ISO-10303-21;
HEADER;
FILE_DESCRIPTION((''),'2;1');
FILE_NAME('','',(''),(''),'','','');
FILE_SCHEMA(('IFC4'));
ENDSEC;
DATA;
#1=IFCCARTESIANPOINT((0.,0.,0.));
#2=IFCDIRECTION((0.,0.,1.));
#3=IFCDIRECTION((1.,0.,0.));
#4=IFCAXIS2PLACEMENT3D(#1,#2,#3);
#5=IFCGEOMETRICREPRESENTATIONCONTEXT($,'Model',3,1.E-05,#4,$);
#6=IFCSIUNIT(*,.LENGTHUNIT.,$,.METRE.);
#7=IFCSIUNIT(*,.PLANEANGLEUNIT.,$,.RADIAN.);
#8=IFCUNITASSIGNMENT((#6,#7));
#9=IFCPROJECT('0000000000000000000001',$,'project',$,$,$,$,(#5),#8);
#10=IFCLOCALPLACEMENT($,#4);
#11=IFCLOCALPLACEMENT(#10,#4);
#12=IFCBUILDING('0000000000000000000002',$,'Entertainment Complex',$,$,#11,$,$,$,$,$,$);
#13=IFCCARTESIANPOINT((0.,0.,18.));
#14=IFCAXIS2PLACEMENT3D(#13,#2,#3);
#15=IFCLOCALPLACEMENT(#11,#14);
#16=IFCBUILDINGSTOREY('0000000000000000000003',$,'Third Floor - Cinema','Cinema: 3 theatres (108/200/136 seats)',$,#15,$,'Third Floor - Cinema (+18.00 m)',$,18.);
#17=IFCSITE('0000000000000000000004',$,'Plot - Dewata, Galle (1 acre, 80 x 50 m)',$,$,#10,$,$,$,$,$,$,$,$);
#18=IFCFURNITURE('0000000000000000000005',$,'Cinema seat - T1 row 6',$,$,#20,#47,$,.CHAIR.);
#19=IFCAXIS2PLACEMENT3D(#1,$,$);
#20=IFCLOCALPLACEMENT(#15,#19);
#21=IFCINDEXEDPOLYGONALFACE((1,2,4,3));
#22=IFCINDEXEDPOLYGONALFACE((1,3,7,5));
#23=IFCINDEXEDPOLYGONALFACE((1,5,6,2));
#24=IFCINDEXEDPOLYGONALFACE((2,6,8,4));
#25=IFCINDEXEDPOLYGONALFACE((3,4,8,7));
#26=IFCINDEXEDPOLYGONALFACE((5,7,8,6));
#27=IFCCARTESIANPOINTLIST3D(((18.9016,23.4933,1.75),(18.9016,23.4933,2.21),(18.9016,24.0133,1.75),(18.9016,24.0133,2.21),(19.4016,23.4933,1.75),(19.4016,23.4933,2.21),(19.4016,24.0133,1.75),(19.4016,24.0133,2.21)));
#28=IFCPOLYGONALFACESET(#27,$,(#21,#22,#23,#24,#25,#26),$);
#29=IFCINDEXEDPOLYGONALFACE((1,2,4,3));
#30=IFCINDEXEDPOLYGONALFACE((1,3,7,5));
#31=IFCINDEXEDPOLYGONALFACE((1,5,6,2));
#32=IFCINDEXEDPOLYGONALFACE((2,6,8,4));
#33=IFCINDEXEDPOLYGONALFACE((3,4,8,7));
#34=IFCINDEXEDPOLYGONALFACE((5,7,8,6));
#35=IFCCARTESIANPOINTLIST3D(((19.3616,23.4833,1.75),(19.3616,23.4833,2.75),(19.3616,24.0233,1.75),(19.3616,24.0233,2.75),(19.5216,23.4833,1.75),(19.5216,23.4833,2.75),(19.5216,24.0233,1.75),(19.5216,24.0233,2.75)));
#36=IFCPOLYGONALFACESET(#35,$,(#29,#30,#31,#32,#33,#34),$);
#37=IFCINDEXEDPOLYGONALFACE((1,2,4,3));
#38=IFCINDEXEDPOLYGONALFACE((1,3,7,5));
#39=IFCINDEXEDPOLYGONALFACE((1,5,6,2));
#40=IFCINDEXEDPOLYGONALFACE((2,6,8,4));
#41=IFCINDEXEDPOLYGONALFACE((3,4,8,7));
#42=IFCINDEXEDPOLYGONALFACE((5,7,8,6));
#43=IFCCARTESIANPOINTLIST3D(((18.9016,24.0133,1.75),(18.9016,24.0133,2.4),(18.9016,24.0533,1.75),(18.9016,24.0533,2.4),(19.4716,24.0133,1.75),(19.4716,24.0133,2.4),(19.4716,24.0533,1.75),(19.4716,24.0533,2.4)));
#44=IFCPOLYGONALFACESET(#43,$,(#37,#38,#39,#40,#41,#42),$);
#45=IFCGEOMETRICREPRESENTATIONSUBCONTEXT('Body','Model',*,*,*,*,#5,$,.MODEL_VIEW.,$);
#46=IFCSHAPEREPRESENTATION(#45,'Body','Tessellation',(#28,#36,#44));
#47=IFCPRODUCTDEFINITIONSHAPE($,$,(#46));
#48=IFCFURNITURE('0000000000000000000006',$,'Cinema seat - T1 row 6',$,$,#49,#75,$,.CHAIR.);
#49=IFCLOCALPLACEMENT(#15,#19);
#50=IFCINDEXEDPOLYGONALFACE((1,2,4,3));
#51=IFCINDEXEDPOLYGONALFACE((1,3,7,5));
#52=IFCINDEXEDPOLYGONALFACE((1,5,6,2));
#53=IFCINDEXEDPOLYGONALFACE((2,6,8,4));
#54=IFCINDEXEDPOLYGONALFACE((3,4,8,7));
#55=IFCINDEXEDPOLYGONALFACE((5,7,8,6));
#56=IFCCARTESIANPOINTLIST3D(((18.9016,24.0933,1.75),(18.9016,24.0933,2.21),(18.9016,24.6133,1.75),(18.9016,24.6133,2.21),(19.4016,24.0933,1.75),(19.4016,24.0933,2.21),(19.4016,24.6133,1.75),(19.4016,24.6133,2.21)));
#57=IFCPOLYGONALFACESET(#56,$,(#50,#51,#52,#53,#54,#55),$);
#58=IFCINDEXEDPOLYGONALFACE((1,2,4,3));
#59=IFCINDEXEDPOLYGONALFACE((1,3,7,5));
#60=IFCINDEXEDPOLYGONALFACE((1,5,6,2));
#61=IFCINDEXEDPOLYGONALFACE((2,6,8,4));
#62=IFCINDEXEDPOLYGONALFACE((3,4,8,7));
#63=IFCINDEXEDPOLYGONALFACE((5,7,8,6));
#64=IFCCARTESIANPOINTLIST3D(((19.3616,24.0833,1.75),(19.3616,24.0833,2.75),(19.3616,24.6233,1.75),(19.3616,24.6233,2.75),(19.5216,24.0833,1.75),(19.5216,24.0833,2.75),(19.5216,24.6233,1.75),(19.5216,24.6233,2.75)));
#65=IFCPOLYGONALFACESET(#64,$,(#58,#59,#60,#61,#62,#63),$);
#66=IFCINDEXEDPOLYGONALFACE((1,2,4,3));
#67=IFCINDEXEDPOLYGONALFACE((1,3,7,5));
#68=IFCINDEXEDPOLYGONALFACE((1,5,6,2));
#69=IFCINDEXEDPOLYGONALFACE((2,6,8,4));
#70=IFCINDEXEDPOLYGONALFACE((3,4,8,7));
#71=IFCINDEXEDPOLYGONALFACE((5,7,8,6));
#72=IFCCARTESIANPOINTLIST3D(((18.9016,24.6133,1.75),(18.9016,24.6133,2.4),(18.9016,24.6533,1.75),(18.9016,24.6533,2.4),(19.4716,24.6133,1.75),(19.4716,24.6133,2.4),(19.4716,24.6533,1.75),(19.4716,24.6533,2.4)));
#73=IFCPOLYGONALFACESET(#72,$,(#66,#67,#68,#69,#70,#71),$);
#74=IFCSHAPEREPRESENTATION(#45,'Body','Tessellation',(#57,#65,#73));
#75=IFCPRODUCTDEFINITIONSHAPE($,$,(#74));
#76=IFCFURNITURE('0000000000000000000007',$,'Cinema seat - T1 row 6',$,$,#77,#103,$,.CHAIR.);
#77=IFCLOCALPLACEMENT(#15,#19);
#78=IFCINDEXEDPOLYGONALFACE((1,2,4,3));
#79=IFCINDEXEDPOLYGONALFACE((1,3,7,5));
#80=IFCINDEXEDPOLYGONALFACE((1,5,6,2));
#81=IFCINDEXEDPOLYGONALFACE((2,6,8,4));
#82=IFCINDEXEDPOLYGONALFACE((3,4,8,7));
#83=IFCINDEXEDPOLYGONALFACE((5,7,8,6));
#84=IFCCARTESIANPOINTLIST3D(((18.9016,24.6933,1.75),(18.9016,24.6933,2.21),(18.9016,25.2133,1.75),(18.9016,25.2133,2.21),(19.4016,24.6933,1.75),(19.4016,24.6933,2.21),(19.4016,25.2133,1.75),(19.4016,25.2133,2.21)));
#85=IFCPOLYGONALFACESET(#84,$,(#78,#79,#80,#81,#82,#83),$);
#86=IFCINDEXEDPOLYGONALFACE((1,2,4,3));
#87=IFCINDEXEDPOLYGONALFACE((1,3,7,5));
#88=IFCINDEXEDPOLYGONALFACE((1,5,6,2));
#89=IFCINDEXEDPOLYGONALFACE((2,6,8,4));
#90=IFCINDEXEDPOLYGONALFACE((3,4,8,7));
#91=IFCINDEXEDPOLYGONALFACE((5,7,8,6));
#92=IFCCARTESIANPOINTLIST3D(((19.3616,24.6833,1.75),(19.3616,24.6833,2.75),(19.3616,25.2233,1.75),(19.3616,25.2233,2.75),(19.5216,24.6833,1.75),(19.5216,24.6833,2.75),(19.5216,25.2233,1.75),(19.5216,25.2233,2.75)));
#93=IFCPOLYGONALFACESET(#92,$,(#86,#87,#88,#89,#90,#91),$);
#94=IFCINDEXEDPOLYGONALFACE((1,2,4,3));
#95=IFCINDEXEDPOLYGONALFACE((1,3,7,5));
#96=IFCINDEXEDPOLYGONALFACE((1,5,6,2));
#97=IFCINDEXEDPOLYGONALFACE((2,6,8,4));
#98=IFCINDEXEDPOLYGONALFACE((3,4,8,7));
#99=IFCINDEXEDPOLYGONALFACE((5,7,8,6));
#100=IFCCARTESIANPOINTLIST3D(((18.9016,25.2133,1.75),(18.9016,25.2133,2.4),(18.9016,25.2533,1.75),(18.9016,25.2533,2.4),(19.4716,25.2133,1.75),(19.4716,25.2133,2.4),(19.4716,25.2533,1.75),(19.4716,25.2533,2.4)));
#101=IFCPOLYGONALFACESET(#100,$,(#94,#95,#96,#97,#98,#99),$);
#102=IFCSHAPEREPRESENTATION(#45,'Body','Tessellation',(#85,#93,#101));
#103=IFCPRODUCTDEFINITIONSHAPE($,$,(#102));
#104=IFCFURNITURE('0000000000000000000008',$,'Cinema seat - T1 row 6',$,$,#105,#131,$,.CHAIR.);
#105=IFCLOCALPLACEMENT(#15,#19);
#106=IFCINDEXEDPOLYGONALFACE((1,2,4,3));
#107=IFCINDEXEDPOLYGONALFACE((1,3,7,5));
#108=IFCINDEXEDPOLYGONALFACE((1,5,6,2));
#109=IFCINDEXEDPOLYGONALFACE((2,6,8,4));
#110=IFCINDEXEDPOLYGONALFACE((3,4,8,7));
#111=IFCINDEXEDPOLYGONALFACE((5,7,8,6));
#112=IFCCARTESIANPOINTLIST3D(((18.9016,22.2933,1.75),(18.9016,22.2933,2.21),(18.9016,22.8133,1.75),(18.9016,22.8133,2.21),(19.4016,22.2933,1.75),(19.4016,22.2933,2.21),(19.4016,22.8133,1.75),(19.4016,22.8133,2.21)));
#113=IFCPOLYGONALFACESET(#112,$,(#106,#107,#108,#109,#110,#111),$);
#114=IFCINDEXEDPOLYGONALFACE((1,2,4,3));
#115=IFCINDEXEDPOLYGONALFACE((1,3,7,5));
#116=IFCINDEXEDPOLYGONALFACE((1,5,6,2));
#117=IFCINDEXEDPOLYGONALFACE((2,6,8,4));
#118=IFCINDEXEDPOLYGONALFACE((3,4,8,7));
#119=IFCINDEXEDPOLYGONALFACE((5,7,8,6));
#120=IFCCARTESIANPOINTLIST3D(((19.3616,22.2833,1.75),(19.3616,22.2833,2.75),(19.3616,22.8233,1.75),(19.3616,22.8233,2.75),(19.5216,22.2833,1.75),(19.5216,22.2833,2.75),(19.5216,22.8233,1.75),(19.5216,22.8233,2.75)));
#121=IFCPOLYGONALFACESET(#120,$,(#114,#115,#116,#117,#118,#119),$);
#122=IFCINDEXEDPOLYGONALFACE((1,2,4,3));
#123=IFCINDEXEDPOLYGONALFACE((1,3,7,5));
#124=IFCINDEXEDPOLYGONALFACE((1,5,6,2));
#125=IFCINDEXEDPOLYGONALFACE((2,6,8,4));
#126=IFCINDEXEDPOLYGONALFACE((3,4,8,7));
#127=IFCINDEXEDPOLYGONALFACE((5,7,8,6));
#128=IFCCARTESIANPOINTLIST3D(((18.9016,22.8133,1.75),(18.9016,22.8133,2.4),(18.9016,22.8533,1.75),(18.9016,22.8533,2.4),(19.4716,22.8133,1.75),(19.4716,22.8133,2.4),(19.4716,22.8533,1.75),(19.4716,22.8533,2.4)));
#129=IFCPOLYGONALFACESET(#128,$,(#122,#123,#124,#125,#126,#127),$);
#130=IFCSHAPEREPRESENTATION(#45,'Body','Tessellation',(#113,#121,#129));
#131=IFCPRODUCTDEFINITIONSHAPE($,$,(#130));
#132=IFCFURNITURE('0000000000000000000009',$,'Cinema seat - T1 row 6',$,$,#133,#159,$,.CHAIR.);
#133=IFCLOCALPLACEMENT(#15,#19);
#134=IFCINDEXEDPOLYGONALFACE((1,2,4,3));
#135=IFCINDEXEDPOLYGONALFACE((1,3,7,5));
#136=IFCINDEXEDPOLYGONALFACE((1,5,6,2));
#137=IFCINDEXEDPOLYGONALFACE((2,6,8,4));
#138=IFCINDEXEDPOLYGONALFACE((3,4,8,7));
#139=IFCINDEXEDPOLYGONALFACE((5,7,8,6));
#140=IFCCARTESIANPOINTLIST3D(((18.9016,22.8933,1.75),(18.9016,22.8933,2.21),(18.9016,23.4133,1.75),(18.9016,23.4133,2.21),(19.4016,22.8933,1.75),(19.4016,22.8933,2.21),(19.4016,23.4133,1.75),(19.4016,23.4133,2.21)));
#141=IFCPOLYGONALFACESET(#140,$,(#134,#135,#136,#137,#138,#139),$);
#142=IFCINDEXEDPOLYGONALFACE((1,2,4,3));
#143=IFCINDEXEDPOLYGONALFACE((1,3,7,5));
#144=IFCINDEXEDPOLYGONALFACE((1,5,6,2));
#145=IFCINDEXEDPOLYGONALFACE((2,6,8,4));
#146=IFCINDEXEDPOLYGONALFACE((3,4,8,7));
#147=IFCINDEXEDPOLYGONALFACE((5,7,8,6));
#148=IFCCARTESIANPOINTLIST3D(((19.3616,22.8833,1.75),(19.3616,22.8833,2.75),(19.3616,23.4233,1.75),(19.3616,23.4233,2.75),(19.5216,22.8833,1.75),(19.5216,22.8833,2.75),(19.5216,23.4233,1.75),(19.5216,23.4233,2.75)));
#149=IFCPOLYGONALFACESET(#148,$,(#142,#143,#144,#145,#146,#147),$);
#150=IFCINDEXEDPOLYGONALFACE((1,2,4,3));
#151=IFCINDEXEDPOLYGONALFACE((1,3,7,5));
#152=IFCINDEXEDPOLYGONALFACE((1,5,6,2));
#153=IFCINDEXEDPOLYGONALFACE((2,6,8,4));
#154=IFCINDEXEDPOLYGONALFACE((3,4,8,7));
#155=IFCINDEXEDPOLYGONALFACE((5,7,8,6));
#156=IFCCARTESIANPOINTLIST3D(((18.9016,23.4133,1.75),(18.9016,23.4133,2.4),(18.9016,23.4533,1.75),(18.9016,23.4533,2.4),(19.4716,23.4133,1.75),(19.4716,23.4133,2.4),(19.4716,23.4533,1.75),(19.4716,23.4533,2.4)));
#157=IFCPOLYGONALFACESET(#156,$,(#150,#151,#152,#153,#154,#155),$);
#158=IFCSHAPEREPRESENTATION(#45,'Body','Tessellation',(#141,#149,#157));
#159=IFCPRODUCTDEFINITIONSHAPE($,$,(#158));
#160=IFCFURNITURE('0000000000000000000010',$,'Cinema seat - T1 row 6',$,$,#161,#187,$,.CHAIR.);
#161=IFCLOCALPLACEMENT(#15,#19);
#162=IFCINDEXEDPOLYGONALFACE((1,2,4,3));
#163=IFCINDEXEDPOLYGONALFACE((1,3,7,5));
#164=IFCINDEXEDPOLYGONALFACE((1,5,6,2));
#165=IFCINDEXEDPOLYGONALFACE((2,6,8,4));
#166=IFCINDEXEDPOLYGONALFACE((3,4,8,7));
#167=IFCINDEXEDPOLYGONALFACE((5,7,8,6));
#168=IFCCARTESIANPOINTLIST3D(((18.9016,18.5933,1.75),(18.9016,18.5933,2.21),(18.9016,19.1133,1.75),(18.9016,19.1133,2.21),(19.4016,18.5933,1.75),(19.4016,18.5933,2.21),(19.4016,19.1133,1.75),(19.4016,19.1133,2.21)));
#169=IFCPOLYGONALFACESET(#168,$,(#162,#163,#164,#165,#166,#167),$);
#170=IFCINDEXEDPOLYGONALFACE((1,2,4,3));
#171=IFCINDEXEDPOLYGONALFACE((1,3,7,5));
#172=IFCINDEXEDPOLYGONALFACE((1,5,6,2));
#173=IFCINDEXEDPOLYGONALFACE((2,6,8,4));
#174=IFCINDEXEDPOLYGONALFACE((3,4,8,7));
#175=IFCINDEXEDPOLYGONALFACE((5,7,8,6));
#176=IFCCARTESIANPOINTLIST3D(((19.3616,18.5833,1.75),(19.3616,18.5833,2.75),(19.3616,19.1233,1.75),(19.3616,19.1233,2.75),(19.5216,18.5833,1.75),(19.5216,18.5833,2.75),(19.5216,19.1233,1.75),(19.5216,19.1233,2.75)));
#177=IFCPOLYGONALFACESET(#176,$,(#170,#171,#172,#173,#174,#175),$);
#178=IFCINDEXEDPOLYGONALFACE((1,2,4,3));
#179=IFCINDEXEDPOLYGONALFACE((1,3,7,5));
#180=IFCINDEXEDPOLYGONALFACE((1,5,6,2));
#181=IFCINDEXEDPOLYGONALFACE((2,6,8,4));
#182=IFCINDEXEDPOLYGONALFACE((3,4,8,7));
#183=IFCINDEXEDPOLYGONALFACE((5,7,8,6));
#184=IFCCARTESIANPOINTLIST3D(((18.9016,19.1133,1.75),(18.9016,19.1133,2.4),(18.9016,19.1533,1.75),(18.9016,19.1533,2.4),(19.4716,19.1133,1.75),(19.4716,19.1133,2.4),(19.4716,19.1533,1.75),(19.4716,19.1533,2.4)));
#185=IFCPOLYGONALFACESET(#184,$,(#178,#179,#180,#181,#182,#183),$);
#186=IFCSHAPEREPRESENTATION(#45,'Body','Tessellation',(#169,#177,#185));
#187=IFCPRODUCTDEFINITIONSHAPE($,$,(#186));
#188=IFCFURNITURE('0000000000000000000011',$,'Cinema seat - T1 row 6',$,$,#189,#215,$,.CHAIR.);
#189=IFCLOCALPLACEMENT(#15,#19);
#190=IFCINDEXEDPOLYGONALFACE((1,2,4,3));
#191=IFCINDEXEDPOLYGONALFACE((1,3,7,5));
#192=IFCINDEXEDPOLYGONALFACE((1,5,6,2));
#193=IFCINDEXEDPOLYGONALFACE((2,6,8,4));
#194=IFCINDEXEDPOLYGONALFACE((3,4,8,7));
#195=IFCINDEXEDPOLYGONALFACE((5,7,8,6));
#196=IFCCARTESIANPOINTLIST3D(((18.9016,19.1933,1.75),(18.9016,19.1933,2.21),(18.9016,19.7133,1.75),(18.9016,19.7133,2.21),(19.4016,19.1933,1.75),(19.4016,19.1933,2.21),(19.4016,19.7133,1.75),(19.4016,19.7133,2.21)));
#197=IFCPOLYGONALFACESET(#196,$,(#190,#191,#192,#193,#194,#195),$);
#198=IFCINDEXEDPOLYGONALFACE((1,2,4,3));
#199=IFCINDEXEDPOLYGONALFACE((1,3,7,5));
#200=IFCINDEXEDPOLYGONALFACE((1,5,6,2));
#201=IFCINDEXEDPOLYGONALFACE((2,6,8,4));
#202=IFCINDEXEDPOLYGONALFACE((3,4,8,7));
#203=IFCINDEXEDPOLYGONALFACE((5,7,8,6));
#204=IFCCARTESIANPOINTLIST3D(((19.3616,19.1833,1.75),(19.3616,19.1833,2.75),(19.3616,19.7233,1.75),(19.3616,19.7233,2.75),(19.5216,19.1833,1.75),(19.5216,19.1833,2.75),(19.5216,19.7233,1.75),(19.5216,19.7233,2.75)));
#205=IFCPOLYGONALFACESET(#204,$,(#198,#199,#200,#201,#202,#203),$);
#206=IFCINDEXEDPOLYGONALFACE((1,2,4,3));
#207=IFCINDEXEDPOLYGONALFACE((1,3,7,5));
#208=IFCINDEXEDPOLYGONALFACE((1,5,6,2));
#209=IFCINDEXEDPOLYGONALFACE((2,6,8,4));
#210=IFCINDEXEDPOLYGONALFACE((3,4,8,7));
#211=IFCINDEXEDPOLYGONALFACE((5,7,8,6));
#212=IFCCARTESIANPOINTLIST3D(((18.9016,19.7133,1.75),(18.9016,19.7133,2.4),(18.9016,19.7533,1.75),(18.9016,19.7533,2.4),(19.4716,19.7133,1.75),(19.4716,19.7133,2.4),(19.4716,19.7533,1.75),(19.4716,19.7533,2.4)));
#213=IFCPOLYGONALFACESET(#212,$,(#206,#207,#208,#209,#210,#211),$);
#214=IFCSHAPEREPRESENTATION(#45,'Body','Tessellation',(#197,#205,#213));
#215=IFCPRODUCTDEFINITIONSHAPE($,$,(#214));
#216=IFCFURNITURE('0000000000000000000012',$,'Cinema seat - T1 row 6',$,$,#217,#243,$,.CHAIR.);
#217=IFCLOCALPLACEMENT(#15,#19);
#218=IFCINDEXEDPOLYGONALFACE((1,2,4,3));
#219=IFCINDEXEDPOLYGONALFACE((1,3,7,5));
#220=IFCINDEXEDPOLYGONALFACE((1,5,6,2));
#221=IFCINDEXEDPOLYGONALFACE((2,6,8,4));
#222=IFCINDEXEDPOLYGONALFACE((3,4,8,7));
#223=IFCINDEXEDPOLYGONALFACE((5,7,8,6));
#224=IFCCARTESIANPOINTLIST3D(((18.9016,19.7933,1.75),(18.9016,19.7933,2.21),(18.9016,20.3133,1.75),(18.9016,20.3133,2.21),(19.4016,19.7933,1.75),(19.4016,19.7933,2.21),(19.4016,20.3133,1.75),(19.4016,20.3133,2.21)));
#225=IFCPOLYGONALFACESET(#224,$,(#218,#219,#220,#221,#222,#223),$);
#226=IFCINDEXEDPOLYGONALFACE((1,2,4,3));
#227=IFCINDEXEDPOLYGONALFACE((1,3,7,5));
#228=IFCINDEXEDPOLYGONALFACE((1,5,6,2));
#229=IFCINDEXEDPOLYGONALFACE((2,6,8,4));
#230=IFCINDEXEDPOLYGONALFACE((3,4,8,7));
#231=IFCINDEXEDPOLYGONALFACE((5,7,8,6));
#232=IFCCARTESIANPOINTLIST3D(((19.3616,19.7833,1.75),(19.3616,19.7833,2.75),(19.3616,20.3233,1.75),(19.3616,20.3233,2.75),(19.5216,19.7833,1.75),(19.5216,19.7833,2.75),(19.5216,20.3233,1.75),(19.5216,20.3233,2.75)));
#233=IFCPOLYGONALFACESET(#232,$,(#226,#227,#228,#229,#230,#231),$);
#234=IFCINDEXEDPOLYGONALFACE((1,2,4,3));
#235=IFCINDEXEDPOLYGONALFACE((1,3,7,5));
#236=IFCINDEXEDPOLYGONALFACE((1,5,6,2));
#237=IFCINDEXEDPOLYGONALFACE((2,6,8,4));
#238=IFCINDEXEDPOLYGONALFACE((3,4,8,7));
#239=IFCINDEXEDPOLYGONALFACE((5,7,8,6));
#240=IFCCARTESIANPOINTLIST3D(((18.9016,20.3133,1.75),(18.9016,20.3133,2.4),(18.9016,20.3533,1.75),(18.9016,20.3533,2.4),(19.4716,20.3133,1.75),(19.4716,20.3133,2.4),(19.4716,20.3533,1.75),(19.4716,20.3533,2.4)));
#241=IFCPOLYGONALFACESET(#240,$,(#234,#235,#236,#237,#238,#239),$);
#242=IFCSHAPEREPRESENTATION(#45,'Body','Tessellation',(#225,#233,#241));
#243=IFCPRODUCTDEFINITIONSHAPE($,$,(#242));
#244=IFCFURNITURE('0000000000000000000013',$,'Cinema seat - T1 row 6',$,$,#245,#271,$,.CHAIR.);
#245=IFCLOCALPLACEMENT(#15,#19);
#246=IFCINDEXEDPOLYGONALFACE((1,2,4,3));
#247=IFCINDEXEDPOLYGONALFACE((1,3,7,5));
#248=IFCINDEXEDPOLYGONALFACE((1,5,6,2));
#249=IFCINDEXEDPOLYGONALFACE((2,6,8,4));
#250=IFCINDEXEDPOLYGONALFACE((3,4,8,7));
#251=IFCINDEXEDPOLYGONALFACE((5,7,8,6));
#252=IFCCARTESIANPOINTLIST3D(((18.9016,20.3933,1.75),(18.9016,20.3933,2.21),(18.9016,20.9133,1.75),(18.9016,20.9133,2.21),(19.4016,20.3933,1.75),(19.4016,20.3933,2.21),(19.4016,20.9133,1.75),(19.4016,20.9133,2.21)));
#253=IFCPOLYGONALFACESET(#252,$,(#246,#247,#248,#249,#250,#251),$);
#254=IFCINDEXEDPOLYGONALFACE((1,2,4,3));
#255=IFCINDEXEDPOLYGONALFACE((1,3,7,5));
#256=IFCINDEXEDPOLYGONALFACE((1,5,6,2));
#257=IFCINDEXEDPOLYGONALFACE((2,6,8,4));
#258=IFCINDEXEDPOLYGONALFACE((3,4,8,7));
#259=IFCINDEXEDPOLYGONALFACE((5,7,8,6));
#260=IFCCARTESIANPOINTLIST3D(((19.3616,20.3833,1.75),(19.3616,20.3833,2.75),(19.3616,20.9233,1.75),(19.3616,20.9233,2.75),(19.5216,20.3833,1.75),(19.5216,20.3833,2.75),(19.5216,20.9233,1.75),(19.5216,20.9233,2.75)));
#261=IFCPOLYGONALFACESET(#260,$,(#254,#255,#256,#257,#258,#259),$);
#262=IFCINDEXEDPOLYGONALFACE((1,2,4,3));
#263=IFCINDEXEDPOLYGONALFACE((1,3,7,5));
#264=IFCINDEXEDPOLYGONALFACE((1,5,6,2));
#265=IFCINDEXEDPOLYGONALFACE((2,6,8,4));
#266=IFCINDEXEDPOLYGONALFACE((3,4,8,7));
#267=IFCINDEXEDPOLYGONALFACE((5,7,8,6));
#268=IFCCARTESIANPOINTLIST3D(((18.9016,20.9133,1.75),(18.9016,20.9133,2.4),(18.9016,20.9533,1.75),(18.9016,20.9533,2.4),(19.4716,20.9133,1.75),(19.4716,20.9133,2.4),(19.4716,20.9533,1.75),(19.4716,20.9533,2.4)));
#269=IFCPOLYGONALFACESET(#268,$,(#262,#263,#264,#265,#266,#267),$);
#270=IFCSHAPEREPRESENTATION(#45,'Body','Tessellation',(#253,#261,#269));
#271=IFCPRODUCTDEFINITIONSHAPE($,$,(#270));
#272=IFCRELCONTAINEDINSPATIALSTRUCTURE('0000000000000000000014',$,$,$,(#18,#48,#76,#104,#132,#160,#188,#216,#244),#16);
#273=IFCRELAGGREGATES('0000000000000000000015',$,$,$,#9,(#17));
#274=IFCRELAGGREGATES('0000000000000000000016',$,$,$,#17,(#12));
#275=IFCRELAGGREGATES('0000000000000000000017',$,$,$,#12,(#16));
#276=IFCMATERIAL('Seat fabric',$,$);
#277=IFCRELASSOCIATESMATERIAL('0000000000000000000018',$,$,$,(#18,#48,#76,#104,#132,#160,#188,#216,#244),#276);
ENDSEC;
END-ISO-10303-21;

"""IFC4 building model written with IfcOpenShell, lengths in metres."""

from ifc_helpers import new_model, si_unit, frame, origin_with_axes, place, context, subcontext, project, spatial, polyline, outline, extrude, material, element, save


model = new_model("IFC4")

# Units and contexts
model_context = context("Model", 3, precision=1e-05, world=origin_with_axes())
body_context = subcontext(model_context, "Body", "Model", "MODEL_VIEW")
ifc_project = project(units=[si_unit("LENGTHUNIT", "METRE"), si_unit("PLANEANGLEUNIT", "RADIAN")], contexts=[model_context])

# Site, building, storey
site_placement = place(None, origin_with_axes())
site = spatial("IfcSite", under=ifc_project, at=site_placement, Name="Plot - Dewata, Galle (1 acre, 80 x 50 m)")
building_placement = place(site_placement, origin_with_axes())
building = spatial("IfcBuilding", under=site, at=building_placement, Name="Entertainment Complex")
storey_placement = place(building_placement, frame((0.0, 0.0, 18.0), z_axis=(0.0, 0.0, 1.0), x_axis=(1.0, 0.0, 0.0)))
storey = spatial("IfcBuildingStorey", under=building, at=storey_placement, Name="Third Floor - Cinema", Description="Cinema: 3 theatres (108/200/136 seats)", LongName="Third Floor - Cinema (+18.00 m)", Elevation=18.0)

# Furniture
ifc_material = material(Name="Seat fabric")
for number, where, z_axis, x_axis, name in (
    (1, (19.5216, 23.7533, 1.75), (0.0, 0.0, 1.0), (1.0, 0.0, 0.0), "Cinema seat - T1 row 6"),
    (2, (19.5216, 24.3533, 1.75), (0.0, 0.0, 1.0), (1.0, 0.0, 0.0), "Cinema seat - T1 row 6"),
    (3, (19.5216, 24.9533, 1.75), (0.0, 0.0, 1.0), (1.0, 0.0, 0.0), "Cinema seat - T1 row 6"),
    (4, (19.5216, 22.5533, 1.75), (0.0, 0.0, 1.0), (1.0, 0.0, 0.0), "Cinema seat - T1 row 6"),
    (5, (19.5216, 23.1533, 1.75), (0.0, 0.0, 1.0), (1.0, 0.0, 0.0), "Cinema seat - T1 row 6"),
    (6, (19.5216, 18.8533, 1.75), (0.0, 0.0, 1.0), (1.0, 0.0, 0.0), "Cinema seat - T1 row 6"),
    (7, (19.5216, 19.4533, 1.75), (0.0, 0.0, 1.0), (1.0, 0.0, 0.0), "Cinema seat - T1 row 6"),
    (8, (19.5216, 20.0533, 1.75), (0.0, 0.0, 1.0), (1.0, 0.0, 0.0), "Cinema seat - T1 row 6"),
    (9, (19.5216, 20.6533, 1.75), (0.0, 0.0, 1.0), (1.0, 0.0, 0.0), "Cinema seat - T1 row 6"),
):
    element("IfcFurniture", number, at=place(storey_placement, frame(where, z_axis=z_axis, x_axis=x_axis)), inside=storey, material=ifc_material, Name=name, PredefinedType="CHAIR", context=body_context, shape_type="SweptSolid", body=[
        extrude(outline(polyline([(-0.62, -0.26), (-0.12, -0.26), (-0.12, 0.26), (-0.62, 0.26), (-0.62, -0.26)])), origin_with_axes(), (0.0, 0.0, 1.0), 0.46),
        extrude(outline(polyline([(-0.16, -0.27), (0.0, -0.27), (0.0, 0.27), (-0.16, 0.27), (-0.16, -0.27)])), origin_with_axes(), (0.0, 0.0, 1.0), 1.0),
        extrude(outline(polyline([(-0.62, 0.26), (-0.05, 0.26), (-0.05, 0.3), (-0.62, 0.3), (-0.62, 0.26)])), origin_with_axes(), (0.0, 0.0, 1.0), 0.65),
    ])

save(model, "model.ifc")
